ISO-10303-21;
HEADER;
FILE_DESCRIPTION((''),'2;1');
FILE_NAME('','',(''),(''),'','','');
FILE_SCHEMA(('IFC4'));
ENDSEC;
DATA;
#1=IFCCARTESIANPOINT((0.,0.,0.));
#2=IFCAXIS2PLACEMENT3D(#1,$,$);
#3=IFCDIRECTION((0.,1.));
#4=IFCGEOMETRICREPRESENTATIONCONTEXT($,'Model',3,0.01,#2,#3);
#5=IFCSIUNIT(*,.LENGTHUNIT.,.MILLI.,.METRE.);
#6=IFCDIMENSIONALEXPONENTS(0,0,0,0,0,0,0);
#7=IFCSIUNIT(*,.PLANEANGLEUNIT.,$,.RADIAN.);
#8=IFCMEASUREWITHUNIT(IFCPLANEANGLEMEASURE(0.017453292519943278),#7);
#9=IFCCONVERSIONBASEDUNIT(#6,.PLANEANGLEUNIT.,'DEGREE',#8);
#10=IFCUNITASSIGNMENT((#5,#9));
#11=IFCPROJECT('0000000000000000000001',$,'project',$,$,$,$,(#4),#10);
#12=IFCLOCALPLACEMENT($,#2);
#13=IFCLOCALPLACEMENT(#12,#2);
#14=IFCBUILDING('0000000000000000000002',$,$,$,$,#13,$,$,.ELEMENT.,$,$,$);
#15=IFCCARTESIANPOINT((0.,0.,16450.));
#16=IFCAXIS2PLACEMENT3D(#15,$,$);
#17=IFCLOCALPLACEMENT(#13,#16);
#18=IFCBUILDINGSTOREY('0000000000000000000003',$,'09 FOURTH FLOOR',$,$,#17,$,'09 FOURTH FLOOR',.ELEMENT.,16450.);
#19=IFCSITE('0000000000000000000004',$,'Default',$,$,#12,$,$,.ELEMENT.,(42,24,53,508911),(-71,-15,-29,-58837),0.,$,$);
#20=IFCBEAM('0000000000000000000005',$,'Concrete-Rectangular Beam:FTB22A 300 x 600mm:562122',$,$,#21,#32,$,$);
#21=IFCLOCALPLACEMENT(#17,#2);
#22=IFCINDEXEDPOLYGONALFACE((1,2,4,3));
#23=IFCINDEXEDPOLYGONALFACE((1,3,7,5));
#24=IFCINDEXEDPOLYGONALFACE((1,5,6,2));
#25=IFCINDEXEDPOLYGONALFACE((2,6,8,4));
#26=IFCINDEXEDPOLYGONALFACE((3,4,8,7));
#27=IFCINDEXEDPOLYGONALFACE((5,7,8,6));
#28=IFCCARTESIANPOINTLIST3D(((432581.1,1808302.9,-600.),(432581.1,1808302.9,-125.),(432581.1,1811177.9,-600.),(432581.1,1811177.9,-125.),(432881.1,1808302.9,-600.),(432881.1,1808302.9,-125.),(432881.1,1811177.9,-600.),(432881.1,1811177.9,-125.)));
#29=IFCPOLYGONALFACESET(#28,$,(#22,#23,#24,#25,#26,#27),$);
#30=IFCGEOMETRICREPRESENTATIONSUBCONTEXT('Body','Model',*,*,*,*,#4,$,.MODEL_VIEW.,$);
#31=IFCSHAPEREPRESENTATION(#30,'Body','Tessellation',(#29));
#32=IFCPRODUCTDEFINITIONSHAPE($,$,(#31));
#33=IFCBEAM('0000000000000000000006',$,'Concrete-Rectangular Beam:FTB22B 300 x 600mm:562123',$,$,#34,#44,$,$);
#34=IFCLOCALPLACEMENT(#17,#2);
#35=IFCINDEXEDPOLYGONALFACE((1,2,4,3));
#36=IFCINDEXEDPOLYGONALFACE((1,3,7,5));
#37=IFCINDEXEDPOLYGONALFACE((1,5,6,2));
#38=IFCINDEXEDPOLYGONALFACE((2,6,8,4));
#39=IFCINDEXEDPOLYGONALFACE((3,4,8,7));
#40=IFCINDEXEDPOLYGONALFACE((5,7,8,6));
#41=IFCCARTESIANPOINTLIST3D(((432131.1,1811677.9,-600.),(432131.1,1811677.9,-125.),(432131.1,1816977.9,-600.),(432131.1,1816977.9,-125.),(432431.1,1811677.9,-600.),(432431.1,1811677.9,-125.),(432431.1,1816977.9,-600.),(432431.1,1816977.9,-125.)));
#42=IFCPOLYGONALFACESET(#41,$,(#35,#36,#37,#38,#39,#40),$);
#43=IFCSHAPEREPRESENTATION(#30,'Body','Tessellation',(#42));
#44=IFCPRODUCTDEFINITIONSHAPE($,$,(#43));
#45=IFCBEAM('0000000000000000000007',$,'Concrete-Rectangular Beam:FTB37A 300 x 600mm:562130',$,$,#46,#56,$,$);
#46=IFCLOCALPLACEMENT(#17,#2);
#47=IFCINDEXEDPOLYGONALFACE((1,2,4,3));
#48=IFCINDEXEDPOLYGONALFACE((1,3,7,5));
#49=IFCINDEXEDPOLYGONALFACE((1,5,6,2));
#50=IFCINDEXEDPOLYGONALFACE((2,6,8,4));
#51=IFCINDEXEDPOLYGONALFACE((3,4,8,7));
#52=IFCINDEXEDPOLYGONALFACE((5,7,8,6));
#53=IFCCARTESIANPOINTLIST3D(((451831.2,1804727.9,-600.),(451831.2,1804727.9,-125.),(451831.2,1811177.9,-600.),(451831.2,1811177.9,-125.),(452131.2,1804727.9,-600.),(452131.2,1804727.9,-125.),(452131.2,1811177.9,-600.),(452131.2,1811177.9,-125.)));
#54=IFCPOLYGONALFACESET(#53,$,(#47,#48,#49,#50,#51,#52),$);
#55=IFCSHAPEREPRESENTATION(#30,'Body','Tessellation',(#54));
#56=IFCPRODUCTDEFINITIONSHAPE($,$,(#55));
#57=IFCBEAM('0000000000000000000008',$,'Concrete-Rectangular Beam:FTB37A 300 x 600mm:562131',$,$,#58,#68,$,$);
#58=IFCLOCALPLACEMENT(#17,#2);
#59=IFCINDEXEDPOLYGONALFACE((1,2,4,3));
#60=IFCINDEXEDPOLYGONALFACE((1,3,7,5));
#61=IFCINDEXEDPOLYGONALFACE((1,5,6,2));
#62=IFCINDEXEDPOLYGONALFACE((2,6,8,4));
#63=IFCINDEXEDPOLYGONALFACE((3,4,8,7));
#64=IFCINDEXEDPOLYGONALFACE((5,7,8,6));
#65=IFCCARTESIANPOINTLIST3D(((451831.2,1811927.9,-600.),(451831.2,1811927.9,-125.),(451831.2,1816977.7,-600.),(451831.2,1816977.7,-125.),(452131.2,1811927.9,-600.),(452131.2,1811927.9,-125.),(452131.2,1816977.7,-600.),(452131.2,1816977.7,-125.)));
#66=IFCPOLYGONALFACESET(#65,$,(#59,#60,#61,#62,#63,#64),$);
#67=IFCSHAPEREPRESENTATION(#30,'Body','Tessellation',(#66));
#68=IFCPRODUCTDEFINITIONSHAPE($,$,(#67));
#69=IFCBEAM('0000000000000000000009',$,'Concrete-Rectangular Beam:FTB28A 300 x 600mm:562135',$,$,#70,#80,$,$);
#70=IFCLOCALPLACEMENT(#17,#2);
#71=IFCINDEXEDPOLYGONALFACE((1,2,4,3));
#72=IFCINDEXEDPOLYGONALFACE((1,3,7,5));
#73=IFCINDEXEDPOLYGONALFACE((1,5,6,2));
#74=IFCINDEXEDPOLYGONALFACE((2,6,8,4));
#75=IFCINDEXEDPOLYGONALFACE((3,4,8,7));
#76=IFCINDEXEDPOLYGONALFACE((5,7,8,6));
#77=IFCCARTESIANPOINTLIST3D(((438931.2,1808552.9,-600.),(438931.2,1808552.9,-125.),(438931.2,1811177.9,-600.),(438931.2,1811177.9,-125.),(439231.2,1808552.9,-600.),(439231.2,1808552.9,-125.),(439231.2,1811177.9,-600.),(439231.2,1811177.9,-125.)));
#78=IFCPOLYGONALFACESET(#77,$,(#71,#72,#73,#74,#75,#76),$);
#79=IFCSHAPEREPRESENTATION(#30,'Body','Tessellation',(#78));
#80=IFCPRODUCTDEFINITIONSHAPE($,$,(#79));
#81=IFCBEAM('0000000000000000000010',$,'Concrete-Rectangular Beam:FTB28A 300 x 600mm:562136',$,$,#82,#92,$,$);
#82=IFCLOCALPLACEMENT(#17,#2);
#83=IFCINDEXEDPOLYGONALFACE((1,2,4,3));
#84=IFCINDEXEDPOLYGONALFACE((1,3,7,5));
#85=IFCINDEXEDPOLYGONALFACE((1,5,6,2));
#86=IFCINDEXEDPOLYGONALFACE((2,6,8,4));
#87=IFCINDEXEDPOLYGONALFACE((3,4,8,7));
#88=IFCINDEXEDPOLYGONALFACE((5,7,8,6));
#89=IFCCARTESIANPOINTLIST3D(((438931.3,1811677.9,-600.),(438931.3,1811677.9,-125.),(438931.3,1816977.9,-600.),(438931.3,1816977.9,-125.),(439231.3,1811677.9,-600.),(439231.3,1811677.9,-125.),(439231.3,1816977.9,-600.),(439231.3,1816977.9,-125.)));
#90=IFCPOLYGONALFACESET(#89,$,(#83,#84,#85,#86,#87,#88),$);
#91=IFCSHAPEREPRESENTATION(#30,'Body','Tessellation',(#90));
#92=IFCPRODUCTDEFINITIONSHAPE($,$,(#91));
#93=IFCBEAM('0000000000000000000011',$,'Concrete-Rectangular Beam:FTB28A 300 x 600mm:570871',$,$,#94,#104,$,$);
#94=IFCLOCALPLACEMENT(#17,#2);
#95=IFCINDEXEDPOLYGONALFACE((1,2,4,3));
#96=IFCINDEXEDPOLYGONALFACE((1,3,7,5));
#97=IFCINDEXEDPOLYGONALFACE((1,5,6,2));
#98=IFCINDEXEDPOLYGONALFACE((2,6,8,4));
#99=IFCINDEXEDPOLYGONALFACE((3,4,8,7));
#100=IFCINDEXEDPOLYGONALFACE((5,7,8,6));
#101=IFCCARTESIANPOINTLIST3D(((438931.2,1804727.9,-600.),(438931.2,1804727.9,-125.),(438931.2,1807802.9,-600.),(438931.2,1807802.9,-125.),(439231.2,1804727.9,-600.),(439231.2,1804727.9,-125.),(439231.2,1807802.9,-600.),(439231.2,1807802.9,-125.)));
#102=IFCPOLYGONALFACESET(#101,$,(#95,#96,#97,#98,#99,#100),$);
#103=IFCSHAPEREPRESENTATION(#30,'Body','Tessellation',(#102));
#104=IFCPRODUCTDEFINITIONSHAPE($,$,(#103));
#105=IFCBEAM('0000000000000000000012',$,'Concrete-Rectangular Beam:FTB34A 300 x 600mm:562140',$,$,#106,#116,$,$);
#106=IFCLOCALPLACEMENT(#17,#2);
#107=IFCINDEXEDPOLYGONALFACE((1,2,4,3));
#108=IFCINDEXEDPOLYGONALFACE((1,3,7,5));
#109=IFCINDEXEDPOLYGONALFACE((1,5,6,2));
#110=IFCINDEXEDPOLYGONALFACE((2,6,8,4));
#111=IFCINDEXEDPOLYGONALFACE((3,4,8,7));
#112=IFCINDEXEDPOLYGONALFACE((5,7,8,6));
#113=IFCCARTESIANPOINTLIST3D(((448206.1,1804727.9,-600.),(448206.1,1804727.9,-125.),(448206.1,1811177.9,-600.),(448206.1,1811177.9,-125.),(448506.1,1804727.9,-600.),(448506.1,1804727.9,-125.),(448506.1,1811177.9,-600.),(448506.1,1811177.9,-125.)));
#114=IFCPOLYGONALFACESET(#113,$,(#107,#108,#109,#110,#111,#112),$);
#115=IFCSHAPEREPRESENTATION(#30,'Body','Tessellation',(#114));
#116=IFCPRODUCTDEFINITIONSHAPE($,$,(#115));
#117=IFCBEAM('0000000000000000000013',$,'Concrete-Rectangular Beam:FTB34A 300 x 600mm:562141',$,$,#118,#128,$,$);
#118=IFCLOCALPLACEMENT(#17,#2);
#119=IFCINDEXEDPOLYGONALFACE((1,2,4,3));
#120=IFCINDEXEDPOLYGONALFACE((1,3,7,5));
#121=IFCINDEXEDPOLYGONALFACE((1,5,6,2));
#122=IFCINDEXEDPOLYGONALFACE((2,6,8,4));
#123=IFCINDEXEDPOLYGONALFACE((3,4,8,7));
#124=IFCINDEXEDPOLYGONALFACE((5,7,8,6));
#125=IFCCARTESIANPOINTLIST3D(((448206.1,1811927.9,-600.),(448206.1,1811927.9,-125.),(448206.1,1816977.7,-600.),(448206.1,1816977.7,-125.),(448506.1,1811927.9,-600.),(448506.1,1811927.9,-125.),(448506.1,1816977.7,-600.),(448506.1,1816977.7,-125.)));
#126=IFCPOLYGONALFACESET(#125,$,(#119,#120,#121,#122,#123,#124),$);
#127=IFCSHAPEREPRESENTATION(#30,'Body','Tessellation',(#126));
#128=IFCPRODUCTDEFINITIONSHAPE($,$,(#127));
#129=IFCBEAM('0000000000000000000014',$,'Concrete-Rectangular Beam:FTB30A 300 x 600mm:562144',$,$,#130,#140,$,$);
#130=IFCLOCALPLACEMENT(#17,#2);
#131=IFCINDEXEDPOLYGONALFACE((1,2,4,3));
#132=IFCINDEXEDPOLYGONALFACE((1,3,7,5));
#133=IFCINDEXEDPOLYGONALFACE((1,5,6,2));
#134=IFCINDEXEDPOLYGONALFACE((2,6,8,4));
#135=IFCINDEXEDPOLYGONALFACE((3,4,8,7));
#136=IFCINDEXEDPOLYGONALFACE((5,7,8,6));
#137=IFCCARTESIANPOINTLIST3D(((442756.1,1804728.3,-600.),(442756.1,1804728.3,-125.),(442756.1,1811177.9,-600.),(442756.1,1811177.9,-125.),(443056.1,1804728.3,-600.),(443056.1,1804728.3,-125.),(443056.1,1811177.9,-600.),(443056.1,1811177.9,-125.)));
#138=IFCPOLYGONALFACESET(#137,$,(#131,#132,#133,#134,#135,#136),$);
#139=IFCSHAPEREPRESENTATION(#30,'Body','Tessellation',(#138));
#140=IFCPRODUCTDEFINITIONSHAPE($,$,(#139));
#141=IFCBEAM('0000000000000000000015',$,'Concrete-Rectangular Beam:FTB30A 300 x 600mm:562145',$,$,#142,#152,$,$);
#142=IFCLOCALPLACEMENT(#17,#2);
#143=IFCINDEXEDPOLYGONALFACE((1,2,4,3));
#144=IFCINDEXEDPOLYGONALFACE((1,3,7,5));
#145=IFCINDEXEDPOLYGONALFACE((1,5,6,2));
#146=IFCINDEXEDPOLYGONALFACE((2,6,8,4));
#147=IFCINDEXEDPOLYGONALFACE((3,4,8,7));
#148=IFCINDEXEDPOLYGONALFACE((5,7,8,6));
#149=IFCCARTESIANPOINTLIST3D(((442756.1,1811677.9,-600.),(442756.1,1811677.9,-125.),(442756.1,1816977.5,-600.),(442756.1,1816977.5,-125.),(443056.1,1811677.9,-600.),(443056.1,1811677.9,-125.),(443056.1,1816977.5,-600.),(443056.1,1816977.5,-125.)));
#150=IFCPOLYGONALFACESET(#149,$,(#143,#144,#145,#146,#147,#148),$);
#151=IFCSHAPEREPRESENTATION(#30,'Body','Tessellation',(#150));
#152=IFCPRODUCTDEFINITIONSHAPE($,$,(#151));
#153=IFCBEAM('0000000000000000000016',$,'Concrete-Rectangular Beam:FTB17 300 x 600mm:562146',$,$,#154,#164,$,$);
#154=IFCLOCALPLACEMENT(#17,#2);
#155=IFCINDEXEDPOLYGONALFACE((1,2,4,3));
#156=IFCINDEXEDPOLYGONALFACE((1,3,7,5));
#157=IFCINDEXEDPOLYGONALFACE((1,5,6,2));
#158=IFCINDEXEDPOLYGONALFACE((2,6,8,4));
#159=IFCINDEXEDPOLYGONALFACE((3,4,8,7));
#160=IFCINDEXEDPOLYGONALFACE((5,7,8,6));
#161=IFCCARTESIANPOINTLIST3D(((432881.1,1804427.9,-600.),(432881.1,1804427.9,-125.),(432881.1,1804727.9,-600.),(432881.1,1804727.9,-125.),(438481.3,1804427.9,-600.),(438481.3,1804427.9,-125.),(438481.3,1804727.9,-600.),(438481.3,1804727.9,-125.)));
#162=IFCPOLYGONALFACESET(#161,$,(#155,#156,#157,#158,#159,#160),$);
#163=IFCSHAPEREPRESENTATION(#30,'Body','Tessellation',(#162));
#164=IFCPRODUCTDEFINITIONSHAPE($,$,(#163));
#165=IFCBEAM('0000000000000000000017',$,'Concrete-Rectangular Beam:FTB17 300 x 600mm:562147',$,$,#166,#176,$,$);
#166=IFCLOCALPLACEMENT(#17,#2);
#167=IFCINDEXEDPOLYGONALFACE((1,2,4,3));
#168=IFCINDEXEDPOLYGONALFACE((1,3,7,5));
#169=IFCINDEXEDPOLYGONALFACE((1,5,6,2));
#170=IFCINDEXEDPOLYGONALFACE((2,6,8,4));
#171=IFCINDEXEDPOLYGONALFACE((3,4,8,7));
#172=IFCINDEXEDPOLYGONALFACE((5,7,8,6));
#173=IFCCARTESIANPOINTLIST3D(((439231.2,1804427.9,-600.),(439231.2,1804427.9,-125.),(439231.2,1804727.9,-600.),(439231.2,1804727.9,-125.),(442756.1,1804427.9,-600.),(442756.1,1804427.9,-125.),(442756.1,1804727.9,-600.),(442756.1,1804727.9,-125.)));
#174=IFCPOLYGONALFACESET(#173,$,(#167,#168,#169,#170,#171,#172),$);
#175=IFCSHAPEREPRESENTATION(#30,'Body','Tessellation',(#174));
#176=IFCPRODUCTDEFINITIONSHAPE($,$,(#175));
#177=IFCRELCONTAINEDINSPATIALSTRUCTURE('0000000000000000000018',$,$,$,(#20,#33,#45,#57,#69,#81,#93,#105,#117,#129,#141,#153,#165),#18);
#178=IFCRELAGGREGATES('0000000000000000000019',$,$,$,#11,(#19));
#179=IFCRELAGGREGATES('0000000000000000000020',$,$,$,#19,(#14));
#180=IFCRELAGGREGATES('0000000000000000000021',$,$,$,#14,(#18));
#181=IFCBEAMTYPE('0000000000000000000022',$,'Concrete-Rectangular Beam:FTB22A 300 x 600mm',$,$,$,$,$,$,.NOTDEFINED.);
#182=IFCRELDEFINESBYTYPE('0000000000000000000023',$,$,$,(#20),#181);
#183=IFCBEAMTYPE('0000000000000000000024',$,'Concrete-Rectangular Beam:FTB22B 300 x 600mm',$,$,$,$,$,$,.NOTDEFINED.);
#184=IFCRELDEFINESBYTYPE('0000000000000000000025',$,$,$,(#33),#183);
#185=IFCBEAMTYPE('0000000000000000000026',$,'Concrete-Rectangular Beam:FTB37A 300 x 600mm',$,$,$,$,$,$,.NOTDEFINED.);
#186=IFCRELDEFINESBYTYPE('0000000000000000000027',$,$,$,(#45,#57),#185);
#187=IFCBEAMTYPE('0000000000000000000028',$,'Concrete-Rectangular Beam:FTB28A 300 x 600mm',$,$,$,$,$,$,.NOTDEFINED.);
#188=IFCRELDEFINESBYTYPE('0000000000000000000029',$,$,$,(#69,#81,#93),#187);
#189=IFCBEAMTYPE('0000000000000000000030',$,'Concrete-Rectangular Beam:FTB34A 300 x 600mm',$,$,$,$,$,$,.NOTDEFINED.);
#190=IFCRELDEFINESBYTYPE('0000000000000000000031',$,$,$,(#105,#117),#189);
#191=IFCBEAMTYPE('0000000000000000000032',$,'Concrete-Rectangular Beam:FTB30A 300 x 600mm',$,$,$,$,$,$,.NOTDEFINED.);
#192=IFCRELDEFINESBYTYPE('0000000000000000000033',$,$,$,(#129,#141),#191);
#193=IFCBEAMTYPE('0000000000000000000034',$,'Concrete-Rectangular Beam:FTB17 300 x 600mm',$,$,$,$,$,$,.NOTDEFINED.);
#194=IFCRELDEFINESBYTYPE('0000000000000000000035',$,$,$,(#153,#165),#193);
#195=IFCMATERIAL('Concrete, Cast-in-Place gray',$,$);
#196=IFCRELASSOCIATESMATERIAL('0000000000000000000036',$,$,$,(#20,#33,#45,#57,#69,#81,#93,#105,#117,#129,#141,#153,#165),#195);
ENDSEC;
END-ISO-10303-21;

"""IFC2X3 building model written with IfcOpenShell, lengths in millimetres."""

from ifc_helpers import new_model, entity, si_unit, converted_unit, direction, frame, frame_2d, origin, place, context, subcontext, project, spatial, rectangle, extrude, material, type_object, element, save


model = new_model("IFC2X3")

# Units and contexts
model_context = context("Model", 3, precision=0.01, world=origin(), true_north=direction((0.0, 1.0)))
body_context = subcontext(model_context, "Body", "Model", "MODEL_VIEW")
ifc_project = project(units=[si_unit("LENGTHUNIT", "METRE", prefix="MILLI"), converted_unit("PLANEANGLEUNIT", "DEGREE", entity("IfcPlaneAngleMeasure", 0.017453292519943278), si_unit("PLANEANGLEUNIT", "RADIAN"), dimensions=[0, 0, 0, 0, 0, 0, 0])], contexts=[model_context])

# Site, building, storey
site_placement = place(None, origin())
site = spatial("IfcSite", under=ifc_project, at=site_placement, Name="Default", CompositionType="ELEMENT", RefLatitude=(42, 24, 53, 508911), RefLongitude=(-71, -15, -29, -58837), RefElevation=0.0)
building_placement = place(site_placement, origin())
building = spatial("IfcBuilding", under=site, at=building_placement, CompositionType="ELEMENT")
storey_placement = place(building_placement, frame((0.0, 0.0, 16450.0)))
storey = spatial("IfcBuildingStorey", under=building, at=storey_placement, Name="09 FOURTH FLOOR", LongName="09 FOURTH FLOOR", CompositionType="ELEMENT", Elevation=16450.0)

# Beams
ifc_material = material(Name="Concrete, Cast-in-Place gray")
beam_type_1 = type_object("IfcBeamType", Name="Concrete-Rectangular Beam:FTB22A 300 x 600mm", PredefinedType="NOTDEFINED")
beam_1_placement = place(storey_placement, frame((432881.1, 1808302.9, 0.0), z_axis=(0.0, 0.0, 1.0), x_axis=(0.0, 1.0, 0.0)))
element("IfcBeam", 1, at=beam_1_placement, inside=storey, type_object=beam_type_1, material=ifc_material, Name="Concrete-Rectangular Beam:FTB22A 300 x 600mm:562122", context=body_context, shape_type="SweptSolid", body=[
    extrude(rectangle(XDim=475.0, YDim=300.0, at=frame_2d((0.0, 0.0), x_axis=(1.0, 0.0))), frame((0.0, 150.0, -362.5), z_axis=(1.0, 0.0, 0.0), x_axis=(0.0, 0.0, -1.0)), (0.0, 0.0, 1.0), 2875.0),
])
beam_type_2 = type_object("IfcBeamType", Name="Concrete-Rectangular Beam:FTB22B 300 x 600mm", PredefinedType="NOTDEFINED")
beam_2_placement = place(storey_placement, frame((432431.1, 1811677.9, 0.0), z_axis=(0.0, 0.0, 1.0), x_axis=(0.0, 1.0, 0.0)))
element("IfcBeam", 2, at=beam_2_placement, inside=storey, type_object=beam_type_2, material=ifc_material, Name="Concrete-Rectangular Beam:FTB22B 300 x 600mm:562123", context=body_context, shape_type="SweptSolid", body=[
    extrude(rectangle(XDim=475.0, YDim=300.0, at=frame_2d((0.0, 0.0), x_axis=(1.0, 0.0))), frame((0.0, 150.0, -362.5), z_axis=(1.0, 0.0, 0.0), x_axis=(0.0, 0.0, -1.0)), (0.0, 0.0, 1.0), 5300.0),
])
beam_type_3 = type_object("IfcBeamType", Name="Concrete-Rectangular Beam:FTB37A 300 x 600mm", PredefinedType="NOTDEFINED")
beam_3_placement = place(storey_placement, frame((451831.2, 1804727.9, 0.0), z_axis=(0.0, 0.0, 1.0), x_axis=(0.0, 1.0, 0.0)))
element("IfcBeam", 3, at=beam_3_placement, inside=storey, type_object=beam_type_3, material=ifc_material, Name="Concrete-Rectangular Beam:FTB37A 300 x 600mm:562130", context=body_context, shape_type="SweptSolid", body=[
    extrude(rectangle(XDim=475.0, YDim=300.0, at=frame_2d((0.0, 0.0), x_axis=(1.0, 0.0))), frame((0.0, -150.0, -362.5), z_axis=(1.0, 0.0, 0.0), x_axis=(0.0, 0.0, -1.0)), (0.0, 0.0, 1.0), 6450.0),
])
beam_4_placement = place(storey_placement, frame((451831.2, 1811927.9, 0.0), z_axis=(0.0, 0.0, 1.0), x_axis=(0.0, 1.0, 0.0)))
element("IfcBeam", 4, at=beam_4_placement, inside=storey, type_object=beam_type_3, material=ifc_material, Name="Concrete-Rectangular Beam:FTB37A 300 x 600mm:562131", context=body_context, shape_type="SweptSolid", body=[
    extrude(rectangle(XDim=475.0, YDim=300.0, at=frame_2d((0.0, 0.0), x_axis=(1.0, 0.0))), frame((0.0, -150.0, -362.5), z_axis=(1.0, 0.0, 0.0), x_axis=(0.0, 0.0, -1.0)), (0.0, 0.0, 1.0), 5049.8),
])
beam_type_4 = type_object("IfcBeamType", Name="Concrete-Rectangular Beam:FTB28A 300 x 600mm", PredefinedType="NOTDEFINED")
beam_5_placement = place(storey_placement, frame((438931.2, 1808552.9, 0.0), z_axis=(0.0, 0.0, 1.0), x_axis=(0.0, 1.0, 0.0)))
element("IfcBeam", 5, at=beam_5_placement, inside=storey, type_object=beam_type_4, material=ifc_material, Name="Concrete-Rectangular Beam:FTB28A 300 x 600mm:562135", context=body_context, shape_type="SweptSolid", body=[
    extrude(rectangle(XDim=475.0, YDim=300.0, at=frame_2d((0.0, 0.0), x_axis=(1.0, 0.0))), frame((0.0, -150.0, -362.5), z_axis=(1.0, 0.0, 0.0), x_axis=(0.0, 0.0, -1.0)), (0.0, 0.0, 1.0), 2625.0),
])
beam_6_placement = place(storey_placement, frame((438931.3, 1811677.9, 0.0), z_axis=(0.0, 0.0, 1.0), x_axis=(0.0, 1.0, 0.0)))
element("IfcBeam", 6, at=beam_6_placement, inside=storey, type_object=beam_type_4, material=ifc_material, Name="Concrete-Rectangular Beam:FTB28A 300 x 600mm:562136", context=body_context, shape_type="SweptSolid", body=[
    extrude(rectangle(XDim=475.0, YDim=300.0, at=frame_2d((0.0, 0.0), x_axis=(1.0, 0.0))), frame((0.0, -150.0, -362.5), z_axis=(1.0, 0.0, 0.0), x_axis=(0.0, 0.0, -1.0)), (0.0, 0.0, 1.0), 5300.0),
])
beam_7_placement = place(storey_placement, frame((439231.2, 1807802.9, 0.0), z_axis=(0.0, 0.0, 1.0), x_axis=(0.0, -1.0, 0.0)))
element("IfcBeam", 7, at=beam_7_placement, inside=storey, type_object=beam_type_4, material=ifc_material, Name="Concrete-Rectangular Beam:FTB28A 300 x 600mm:570871", context=body_context, shape_type="SweptSolid", body=[
    extrude(rectangle(XDim=475.0, YDim=300.0, at=frame_2d((0.0, 0.0), x_axis=(1.0, 0.0))), frame((0.0, -150.0, -362.5), z_axis=(1.0, 0.0, 0.0), x_axis=(0.0, 0.0, -1.0)), (0.0, 0.0, 1.0), 3075.0),
])
beam_type_5 = type_object("IfcBeamType", Name="Concrete-Rectangular Beam:FTB34A 300 x 600mm", PredefinedType="NOTDEFINED")
beam_8_placement = place(storey_placement, frame((448206.1, 1804727.9, 0.0), z_axis=(0.0, 0.0, 1.0), x_axis=(0.0, 1.0, 0.0)))
element("IfcBeam", 8, at=beam_8_placement, inside=storey, type_object=beam_type_5, material=ifc_material, Name="Concrete-Rectangular Beam:FTB34A 300 x 600mm:562140", context=body_context, shape_type="SweptSolid", body=[
    extrude(rectangle(XDim=475.0, YDim=300.0, at=frame_2d((0.0, 0.0), x_axis=(1.0, 0.0))), frame((0.0, -150.0, -362.5), z_axis=(1.0, 0.0, 0.0), x_axis=(0.0, 0.0, -1.0)), (0.0, 0.0, 1.0), 6450.0),
])
beam_9_placement = place(storey_placement, frame((448206.1, 1811927.9, 0.0), z_axis=(0.0, 0.0, 1.0), x_axis=(0.0, 1.0, 0.0)))
element("IfcBeam", 9, at=beam_9_placement, inside=storey, type_object=beam_type_5, material=ifc_material, Name="Concrete-Rectangular Beam:FTB34A 300 x 600mm:562141", context=body_context, shape_type="SweptSolid", body=[
    extrude(rectangle(XDim=475.0, YDim=300.0, at=frame_2d((0.0, 0.0), x_axis=(1.0, 0.0))), frame((0.0, -150.0, -362.5), z_axis=(1.0, 0.0, 0.0), x_axis=(0.0, 0.0, -1.0)), (0.0, 0.0, 1.0), 5049.8),
])
beam_type_6 = type_object("IfcBeamType", Name="Concrete-Rectangular Beam:FTB30A 300 x 600mm", PredefinedType="NOTDEFINED")
beam_10_placement = place(storey_placement, frame((442756.1, 1804728.3, 0.0), z_axis=(0.0, 0.0, 1.0), x_axis=(0.0, 1.0, 0.0)))
element("IfcBeam", 10, at=beam_10_placement, inside=storey, type_object=beam_type_6, material=ifc_material, Name="Concrete-Rectangular Beam:FTB30A 300 x 600mm:562144", context=body_context, shape_type="SweptSolid", body=[
    extrude(rectangle(XDim=475.0, YDim=300.0, at=frame_2d((0.0, 0.0), x_axis=(1.0, 0.0))), frame((0.0, -150.0, -362.5), z_axis=(1.0, 0.0, 0.0), x_axis=(0.0, 0.0, -1.0)), (0.0, 0.0, 1.0), 6449.6),
])
beam_11_placement = place(storey_placement, frame((442756.1, 1811677.9, 0.0), z_axis=(0.0, 0.0, 1.0), x_axis=(0.0, 1.0, 0.0)))
element("IfcBeam", 11, at=beam_11_placement, inside=storey, type_object=beam_type_6, material=ifc_material, Name="Concrete-Rectangular Beam:FTB30A 300 x 600mm:562145", context=body_context, shape_type="SweptSolid", body=[
    extrude(rectangle(XDim=475.0, YDim=300.0, at=frame_2d((0.0, 0.0), x_axis=(1.0, 0.0))), frame((0.0, -150.0, -362.5), z_axis=(1.0, 0.0, 0.0), x_axis=(0.0, 0.0, -1.0)), (0.0, 0.0, 1.0), 5299.6),
])
beam_type_7 = type_object("IfcBeamType", Name="Concrete-Rectangular Beam:FTB17 300 x 600mm", PredefinedType="NOTDEFINED")
beam_12_placement = place(storey_placement, frame((432881.1, 1804727.9, 0.0)))
element("IfcBeam", 12, at=beam_12_placement, inside=storey, type_object=beam_type_7, material=ifc_material, Name="Concrete-Rectangular Beam:FTB17 300 x 600mm:562146", context=body_context, shape_type="SweptSolid", body=[
    extrude(rectangle(XDim=475.0, YDim=300.0, at=frame_2d((0.0, 0.0), x_axis=(1.0, 0.0))), frame((0.0, -150.0, -362.5), z_axis=(1.0, 0.0, 0.0), x_axis=(0.0, 0.0, -1.0)), (0.0, 0.0, 1.0), 5600.2),
])
beam_13_placement = place(storey_placement, frame((439231.2, 1804727.9, 0.0)))
element("IfcBeam", 13, at=beam_13_placement, inside=storey, type_object=beam_type_7, material=ifc_material, Name="Concrete-Rectangular Beam:FTB17 300 x 600mm:562147", context=body_context, shape_type="SweptSolid", body=[
    extrude(rectangle(XDim=475.0, YDim=300.0, at=frame_2d((0.0, 0.0), x_axis=(1.0, 0.0))), frame((0.0, -150.0, -362.5), z_axis=(1.0, 0.0, 0.0), x_axis=(0.0, 0.0, -1.0)), (0.0, 0.0, 1.0), 3524.9),
])

save(model, "model.ifc")
